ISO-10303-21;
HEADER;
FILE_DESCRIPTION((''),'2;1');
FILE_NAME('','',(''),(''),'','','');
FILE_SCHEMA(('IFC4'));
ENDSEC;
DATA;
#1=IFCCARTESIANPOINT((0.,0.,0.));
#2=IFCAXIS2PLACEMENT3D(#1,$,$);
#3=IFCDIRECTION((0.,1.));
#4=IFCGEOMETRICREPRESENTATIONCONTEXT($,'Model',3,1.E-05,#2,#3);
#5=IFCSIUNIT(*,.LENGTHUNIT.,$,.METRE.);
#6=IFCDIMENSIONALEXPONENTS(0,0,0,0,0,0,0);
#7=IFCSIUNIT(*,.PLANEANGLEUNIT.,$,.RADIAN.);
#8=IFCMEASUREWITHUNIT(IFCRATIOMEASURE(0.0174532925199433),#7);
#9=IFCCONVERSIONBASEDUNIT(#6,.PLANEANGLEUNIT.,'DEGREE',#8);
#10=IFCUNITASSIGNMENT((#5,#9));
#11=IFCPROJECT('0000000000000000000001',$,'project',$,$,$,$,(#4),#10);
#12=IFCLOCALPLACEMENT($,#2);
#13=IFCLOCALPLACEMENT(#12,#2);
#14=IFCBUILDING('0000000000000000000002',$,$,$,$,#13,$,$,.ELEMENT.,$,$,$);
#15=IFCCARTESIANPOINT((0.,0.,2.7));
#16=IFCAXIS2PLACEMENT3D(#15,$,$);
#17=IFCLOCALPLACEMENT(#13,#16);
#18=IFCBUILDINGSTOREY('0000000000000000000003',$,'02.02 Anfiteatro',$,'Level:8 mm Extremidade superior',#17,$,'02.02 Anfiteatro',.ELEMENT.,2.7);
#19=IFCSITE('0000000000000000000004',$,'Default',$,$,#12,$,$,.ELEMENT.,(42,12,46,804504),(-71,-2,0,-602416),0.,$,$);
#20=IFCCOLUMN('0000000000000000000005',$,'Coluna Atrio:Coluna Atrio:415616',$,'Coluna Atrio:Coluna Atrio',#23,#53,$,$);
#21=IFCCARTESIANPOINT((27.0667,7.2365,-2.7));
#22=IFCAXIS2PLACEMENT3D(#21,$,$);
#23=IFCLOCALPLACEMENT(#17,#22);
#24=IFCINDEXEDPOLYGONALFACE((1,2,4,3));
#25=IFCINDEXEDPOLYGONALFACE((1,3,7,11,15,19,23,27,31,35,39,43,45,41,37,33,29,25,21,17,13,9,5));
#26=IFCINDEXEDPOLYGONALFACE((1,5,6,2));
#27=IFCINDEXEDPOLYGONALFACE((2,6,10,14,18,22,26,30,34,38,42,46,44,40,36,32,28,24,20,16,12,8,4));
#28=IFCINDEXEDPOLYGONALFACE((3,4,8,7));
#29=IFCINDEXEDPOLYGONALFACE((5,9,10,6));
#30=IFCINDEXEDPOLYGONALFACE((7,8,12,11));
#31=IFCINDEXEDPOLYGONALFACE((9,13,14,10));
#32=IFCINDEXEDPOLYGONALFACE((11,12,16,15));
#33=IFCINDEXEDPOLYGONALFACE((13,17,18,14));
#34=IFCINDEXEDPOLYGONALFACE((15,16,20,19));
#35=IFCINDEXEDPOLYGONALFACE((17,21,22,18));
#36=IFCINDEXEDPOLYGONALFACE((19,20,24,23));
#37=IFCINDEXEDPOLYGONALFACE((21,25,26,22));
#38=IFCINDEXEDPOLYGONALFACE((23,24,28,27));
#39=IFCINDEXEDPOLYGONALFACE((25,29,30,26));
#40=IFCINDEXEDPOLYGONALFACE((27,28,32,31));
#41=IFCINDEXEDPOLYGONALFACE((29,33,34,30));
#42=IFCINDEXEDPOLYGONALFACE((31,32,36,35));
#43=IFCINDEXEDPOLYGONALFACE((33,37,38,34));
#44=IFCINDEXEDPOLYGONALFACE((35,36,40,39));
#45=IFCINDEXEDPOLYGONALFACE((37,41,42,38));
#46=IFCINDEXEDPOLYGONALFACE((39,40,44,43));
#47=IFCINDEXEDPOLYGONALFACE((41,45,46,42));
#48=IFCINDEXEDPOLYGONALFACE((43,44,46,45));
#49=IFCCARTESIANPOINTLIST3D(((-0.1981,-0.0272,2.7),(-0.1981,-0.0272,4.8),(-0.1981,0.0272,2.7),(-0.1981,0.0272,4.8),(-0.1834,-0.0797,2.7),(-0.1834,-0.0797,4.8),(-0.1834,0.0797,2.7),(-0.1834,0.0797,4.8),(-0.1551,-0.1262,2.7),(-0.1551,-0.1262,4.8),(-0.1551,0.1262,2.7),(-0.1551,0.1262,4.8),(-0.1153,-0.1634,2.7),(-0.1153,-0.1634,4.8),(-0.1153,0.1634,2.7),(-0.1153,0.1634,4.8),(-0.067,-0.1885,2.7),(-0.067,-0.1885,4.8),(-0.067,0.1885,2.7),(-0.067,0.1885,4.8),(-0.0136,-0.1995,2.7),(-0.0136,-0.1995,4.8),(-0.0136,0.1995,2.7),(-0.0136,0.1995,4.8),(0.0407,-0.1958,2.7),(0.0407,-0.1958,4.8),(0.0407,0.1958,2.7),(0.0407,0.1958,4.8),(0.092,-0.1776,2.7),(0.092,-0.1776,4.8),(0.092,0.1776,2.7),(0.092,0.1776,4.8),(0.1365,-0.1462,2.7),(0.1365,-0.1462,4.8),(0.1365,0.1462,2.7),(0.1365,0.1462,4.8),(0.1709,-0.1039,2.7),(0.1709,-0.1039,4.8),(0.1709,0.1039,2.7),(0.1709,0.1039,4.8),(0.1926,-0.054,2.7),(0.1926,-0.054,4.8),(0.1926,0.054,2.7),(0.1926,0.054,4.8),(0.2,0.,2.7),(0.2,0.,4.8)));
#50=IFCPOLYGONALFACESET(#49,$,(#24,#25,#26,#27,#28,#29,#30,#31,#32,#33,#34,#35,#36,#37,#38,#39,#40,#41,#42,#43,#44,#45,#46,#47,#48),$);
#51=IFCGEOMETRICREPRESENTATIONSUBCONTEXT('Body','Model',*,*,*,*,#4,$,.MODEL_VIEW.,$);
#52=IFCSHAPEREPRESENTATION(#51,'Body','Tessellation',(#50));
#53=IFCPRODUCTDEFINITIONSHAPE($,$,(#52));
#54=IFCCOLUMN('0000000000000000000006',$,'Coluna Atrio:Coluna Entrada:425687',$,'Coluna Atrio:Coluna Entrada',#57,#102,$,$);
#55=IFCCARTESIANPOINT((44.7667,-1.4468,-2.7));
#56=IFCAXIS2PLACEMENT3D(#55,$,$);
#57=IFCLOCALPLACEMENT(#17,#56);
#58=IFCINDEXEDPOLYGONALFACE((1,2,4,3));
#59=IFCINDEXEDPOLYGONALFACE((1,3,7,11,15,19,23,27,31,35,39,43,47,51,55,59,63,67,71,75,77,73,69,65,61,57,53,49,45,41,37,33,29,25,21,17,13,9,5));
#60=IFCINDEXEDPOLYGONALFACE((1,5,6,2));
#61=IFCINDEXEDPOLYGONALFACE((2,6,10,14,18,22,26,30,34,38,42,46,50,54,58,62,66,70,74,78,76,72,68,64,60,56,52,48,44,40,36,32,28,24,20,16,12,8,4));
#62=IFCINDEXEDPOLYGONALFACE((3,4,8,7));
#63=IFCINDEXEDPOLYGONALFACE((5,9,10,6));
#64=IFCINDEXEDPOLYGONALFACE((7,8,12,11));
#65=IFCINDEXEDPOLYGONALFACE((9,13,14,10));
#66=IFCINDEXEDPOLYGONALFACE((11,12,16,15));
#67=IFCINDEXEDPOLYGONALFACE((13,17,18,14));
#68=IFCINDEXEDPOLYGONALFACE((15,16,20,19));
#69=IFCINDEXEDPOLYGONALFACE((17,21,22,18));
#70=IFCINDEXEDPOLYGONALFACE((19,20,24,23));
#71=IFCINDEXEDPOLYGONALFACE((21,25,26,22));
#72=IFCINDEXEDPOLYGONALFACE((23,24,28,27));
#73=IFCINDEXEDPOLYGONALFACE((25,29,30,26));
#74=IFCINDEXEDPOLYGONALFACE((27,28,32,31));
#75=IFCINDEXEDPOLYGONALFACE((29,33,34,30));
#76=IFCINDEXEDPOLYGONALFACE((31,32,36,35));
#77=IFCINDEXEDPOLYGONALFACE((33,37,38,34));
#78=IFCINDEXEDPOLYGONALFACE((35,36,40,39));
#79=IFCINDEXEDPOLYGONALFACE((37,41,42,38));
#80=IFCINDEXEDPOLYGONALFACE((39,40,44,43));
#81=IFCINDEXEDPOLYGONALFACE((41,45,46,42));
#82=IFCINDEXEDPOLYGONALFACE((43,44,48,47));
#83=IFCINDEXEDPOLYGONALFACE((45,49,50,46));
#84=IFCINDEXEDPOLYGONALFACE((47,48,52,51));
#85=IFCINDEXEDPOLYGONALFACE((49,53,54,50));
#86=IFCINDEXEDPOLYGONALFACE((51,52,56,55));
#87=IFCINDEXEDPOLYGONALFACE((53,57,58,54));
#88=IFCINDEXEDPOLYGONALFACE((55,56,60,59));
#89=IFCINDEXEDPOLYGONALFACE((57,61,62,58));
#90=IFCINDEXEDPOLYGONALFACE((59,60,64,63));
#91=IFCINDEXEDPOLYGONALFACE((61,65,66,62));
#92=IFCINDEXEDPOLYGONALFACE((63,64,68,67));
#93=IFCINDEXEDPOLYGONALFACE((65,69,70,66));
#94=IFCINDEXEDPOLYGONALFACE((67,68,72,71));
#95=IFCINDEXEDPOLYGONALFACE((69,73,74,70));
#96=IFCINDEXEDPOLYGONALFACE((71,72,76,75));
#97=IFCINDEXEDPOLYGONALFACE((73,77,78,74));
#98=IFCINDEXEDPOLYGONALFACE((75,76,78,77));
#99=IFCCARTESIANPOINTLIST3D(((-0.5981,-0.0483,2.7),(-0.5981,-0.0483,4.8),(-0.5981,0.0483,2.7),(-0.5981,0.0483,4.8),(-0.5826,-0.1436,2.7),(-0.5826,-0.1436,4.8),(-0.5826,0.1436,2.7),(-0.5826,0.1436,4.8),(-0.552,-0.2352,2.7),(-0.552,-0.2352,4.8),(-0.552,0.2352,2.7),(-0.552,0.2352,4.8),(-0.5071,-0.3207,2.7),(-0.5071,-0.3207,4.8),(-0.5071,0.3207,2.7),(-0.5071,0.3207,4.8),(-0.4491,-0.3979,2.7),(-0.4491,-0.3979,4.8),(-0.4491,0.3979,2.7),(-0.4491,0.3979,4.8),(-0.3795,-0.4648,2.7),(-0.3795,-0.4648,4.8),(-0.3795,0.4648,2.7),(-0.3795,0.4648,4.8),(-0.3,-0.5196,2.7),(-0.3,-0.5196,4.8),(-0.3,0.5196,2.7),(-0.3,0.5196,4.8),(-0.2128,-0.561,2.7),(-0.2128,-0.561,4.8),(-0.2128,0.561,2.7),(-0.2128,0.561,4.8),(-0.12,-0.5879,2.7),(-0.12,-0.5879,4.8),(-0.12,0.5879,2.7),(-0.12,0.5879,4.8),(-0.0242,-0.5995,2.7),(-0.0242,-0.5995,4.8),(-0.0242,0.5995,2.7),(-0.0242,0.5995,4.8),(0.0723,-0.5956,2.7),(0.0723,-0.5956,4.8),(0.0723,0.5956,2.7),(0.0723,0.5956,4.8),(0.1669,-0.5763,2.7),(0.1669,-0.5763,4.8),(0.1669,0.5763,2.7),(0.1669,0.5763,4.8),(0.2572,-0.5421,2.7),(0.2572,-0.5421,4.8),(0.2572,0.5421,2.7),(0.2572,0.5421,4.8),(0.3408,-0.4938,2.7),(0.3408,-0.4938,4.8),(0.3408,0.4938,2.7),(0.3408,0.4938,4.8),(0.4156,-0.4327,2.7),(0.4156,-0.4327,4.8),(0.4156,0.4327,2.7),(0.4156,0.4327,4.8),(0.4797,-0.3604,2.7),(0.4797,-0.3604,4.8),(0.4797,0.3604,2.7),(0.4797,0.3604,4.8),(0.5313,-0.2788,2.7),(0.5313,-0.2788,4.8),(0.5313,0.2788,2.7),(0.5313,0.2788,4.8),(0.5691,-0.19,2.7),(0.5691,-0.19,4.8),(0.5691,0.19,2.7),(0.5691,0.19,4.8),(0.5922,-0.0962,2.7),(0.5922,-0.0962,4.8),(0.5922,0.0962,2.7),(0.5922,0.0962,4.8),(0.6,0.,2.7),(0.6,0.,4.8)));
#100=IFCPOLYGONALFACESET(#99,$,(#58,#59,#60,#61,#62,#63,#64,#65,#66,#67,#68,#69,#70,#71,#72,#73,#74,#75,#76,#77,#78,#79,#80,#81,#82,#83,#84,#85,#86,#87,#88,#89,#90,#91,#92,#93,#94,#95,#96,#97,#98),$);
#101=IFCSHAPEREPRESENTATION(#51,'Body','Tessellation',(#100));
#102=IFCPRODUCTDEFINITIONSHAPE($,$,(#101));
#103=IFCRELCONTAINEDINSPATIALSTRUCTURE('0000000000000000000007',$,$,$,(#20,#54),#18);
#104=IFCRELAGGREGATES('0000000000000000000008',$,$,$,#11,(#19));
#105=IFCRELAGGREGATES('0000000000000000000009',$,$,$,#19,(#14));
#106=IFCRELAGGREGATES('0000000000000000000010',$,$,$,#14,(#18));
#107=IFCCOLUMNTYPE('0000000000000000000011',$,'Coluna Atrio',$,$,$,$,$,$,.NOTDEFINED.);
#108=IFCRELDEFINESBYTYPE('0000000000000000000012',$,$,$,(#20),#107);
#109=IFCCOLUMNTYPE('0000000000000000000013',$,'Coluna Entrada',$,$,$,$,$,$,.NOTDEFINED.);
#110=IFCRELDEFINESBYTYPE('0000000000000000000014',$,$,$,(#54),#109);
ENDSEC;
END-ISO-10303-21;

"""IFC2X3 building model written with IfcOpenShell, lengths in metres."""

from ifc_helpers import new_model, entity, si_unit, converted_unit, direction, frame, frame_2d, origin, place, context, subcontext, project, spatial, circle, extrude, source, transform, mapped, type_object, type_shapes, element, save


model = new_model("IFC2X3")

# Units and contexts
model_context = context("Model", 3, precision=1e-05, world=origin(), true_north=direction((0.0, 1.0)))
body_context = subcontext(model_context, "Body", "Model", "MODEL_VIEW")
ifc_project = project(units=[si_unit("LENGTHUNIT", "METRE"), converted_unit("PLANEANGLEUNIT", "DEGREE", entity("IfcRatioMeasure", 0.0174532925199433), si_unit("PLANEANGLEUNIT", "RADIAN"), dimensions=[0, 0, 0, 0, 0, 0, 0])], contexts=[model_context])

# Site, building, storey
site_placement = place(None, origin())
site = spatial("IfcSite", under=ifc_project, at=site_placement, Name="Default", CompositionType="ELEMENT", RefLatitude=(42, 12, 46, 804504), RefLongitude=(-71, -2, 0, -602416), RefElevation=0.0)
building_placement = place(site_placement, origin())
building = spatial("IfcBuilding", under=site, at=building_placement, CompositionType="ELEMENT")
storey_placement = place(building_placement, frame((0.0, 0.0, 2.7)))
storey = spatial("IfcBuildingStorey", under=building, at=storey_placement, Name="02.02 Anfiteatro", ObjectType="Level:8 mm Extremidade superior", LongName="02.02 Anfiteatro", CompositionType="ELEMENT", Elevation=2.7)

# Columns
column_type_1 = type_object("IfcColumnType", Name="Coluna Atrio", PredefinedType="NOTDEFINED")
shared_shape_1 = source(origin(), body_context, "Body", "SweptSolid", [
    extrude(circle(Radius=0.2, at=frame_2d((0.0, 0.0), x_axis=(1.0, 0.0))), frame((0.0, 0.0, 2.7)), (0.0, 0.0, 1.0), 2.1),
])
type_shapes(column_type_1, [shared_shape_1])
column_1_placement = place(storey_placement, frame((27.0667, 7.2365, -2.7)))
element("IfcColumn", 1, at=column_1_placement, inside=storey, type_object=column_type_1, Name="Coluna Atrio:Coluna Atrio:415616", ObjectType="Coluna Atrio:Coluna Atrio", context=body_context, shape_type="MappedRepresentation", body=[
    mapped(shared_shape_1, transform((0.0, 0.0, 0.0), scale=1.0)),
])
column_type_2 = type_object("IfcColumnType", Name="Coluna Entrada", PredefinedType="NOTDEFINED")
shared_shape_2 = source(origin(), body_context, "Body", "SweptSolid", [
    extrude(circle(Radius=0.6, at=frame_2d((0.0, 0.0), x_axis=(1.0, 0.0))), frame((0.0, 0.0, 2.7)), (0.0, 0.0, 1.0), 2.1),
])
type_shapes(column_type_2, [shared_shape_2])
column_2_placement = place(storey_placement, frame((44.7667, -1.4468, -2.7)))
element("IfcColumn", 2, at=column_2_placement, inside=storey, type_object=column_type_2, Name="Coluna Atrio:Coluna Entrada:425687", ObjectType="Coluna Atrio:Coluna Entrada", context=body_context, shape_type="MappedRepresentation", body=[
    mapped(shared_shape_2, transform((0.0, 0.0, 0.0), scale=1.0)),
])

save(model, "model.ifc")
